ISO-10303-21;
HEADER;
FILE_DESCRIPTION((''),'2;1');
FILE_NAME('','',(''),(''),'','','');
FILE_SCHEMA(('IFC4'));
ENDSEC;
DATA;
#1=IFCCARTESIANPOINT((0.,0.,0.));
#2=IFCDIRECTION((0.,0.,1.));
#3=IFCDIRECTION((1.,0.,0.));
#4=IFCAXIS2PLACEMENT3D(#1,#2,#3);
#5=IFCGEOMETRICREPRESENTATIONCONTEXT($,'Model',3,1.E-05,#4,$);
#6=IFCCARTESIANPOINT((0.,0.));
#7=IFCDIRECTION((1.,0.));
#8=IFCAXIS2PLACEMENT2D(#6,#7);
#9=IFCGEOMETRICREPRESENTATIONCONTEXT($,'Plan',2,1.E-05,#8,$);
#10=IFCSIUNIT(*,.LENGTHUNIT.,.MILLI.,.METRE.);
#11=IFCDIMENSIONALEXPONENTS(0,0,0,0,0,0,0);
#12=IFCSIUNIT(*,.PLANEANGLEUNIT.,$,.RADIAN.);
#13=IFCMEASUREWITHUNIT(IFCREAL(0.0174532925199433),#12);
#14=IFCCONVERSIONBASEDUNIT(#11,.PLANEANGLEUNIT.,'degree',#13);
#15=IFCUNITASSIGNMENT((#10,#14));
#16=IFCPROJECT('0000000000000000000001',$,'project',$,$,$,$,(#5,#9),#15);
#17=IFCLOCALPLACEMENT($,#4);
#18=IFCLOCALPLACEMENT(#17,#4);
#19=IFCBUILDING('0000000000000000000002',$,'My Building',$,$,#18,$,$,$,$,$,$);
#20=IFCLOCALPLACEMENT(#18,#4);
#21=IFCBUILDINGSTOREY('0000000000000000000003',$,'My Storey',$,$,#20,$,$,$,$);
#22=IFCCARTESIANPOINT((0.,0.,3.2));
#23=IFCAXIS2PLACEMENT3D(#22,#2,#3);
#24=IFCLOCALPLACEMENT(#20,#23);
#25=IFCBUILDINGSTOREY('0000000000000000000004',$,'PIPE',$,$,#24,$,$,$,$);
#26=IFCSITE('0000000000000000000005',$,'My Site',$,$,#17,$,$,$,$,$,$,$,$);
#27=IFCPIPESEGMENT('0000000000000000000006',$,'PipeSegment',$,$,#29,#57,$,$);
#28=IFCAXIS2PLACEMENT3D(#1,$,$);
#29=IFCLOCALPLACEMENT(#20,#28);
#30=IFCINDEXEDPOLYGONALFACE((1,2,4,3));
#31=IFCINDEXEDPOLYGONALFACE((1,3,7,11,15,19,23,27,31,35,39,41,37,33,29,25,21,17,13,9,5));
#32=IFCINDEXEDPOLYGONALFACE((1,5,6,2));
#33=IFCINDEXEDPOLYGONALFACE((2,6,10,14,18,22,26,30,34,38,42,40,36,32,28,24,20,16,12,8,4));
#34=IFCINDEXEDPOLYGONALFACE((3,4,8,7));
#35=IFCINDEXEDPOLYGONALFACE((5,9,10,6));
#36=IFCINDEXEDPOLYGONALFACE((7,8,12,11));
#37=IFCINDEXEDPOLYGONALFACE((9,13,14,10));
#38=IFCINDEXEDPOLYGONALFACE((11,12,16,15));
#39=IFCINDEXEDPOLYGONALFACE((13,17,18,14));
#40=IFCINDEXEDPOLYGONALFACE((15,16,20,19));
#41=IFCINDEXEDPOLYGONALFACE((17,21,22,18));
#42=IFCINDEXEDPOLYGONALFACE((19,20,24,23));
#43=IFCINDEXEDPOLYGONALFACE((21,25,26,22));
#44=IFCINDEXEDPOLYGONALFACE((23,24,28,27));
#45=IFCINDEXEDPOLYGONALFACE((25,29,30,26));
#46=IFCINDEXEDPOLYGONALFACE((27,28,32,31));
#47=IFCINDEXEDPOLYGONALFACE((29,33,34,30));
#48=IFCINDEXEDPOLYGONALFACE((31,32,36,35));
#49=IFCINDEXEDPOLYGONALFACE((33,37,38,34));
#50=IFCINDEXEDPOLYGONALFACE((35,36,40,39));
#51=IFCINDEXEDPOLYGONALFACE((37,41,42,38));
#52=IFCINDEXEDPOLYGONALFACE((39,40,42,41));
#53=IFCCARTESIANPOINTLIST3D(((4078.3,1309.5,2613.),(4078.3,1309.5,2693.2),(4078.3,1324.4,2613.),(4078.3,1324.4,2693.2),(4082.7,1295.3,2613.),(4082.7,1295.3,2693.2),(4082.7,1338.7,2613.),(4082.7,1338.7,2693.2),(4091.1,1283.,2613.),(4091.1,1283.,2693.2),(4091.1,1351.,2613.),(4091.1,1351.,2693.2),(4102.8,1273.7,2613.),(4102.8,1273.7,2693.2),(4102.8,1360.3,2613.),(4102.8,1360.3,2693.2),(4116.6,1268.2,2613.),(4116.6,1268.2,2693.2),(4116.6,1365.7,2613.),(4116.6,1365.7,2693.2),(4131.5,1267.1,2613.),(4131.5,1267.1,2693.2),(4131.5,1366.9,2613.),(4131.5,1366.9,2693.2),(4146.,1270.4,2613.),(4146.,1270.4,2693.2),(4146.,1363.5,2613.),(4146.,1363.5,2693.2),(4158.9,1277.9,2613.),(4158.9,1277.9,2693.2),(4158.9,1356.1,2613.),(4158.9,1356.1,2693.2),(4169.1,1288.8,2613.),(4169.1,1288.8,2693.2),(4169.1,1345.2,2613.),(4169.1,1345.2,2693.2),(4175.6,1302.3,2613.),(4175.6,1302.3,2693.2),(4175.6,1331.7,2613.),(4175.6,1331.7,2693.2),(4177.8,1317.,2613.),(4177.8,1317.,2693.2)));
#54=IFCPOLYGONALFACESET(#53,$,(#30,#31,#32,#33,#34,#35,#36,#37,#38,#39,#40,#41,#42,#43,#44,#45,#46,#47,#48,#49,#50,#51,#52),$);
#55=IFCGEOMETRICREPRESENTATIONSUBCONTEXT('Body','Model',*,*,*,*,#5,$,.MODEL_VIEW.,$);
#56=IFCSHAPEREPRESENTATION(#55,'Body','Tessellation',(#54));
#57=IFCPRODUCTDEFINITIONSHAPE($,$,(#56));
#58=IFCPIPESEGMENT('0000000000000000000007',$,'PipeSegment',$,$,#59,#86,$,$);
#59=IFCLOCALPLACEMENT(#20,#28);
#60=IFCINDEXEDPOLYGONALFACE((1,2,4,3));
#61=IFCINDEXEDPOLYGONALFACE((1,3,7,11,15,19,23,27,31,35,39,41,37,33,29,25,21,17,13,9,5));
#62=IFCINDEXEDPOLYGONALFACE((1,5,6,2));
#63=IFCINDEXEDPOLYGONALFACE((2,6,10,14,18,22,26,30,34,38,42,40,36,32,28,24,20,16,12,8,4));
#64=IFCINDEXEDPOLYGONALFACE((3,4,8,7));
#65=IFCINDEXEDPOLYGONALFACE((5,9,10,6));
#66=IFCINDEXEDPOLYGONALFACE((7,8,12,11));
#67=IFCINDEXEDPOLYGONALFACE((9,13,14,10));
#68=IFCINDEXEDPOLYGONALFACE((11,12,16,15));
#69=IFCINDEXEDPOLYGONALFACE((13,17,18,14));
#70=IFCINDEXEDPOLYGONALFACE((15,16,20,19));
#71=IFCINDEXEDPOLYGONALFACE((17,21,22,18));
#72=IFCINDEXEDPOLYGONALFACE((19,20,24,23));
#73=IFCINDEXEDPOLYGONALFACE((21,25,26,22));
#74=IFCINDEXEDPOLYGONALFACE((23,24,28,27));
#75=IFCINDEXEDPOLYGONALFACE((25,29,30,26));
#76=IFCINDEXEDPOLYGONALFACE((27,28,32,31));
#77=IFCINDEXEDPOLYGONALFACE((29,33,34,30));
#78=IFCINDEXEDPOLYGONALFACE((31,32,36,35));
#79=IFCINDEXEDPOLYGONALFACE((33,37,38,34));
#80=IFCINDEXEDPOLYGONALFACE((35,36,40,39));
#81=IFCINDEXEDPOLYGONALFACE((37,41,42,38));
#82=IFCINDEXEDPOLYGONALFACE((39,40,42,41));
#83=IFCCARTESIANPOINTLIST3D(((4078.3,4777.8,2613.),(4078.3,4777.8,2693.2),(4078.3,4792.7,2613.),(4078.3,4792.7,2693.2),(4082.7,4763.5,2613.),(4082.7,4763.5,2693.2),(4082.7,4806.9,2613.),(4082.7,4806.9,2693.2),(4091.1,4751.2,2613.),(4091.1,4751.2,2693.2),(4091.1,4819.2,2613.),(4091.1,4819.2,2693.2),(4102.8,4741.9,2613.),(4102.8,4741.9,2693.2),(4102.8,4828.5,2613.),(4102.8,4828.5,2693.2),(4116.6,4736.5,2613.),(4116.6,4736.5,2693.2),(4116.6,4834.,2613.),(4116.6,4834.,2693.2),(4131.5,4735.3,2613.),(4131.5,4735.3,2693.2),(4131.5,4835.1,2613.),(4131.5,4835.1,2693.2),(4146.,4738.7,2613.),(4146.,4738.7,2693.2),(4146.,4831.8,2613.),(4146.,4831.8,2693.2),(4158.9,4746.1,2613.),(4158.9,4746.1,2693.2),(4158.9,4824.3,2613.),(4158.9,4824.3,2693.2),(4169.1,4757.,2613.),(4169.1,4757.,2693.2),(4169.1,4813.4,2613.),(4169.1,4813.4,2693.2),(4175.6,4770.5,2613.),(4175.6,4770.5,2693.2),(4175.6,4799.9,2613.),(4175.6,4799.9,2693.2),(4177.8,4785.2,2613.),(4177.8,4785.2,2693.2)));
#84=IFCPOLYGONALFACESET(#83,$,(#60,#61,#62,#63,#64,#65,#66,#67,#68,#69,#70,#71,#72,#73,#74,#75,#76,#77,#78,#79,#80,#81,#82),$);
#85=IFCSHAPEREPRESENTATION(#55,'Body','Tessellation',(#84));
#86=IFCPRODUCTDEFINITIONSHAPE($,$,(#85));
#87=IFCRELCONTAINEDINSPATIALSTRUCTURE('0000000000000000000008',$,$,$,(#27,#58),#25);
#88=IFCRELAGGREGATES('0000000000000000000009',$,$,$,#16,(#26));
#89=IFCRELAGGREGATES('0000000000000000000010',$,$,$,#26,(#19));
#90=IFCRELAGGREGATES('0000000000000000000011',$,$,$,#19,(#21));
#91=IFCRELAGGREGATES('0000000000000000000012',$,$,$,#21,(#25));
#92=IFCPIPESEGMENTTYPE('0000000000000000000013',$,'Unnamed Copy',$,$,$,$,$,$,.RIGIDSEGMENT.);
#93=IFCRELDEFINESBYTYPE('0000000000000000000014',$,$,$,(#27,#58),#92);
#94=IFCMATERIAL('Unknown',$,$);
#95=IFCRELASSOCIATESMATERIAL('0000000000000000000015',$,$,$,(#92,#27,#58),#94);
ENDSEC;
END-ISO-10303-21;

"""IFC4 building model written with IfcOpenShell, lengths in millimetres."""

from ifc_helpers import new_model, entity, si_unit, converted_unit, frame, origin_with_axes, origin_2d_with_axis, place, context, subcontext, project, spatial, circle, extrude, material, material_profile, profile_set, profile_usage, type_object, element, save


model = new_model("IFC4")

# Units and contexts
model_context = context("Model", 3, precision=1e-05, world=origin_with_axes())
plan_context = context("Plan", 2, precision=1e-05, world=origin_2d_with_axis())
body_context = subcontext(model_context, "Body", "Model", "MODEL_VIEW")
ifc_project = project(units=[si_unit("LENGTHUNIT", "METRE", prefix="MILLI"), converted_unit("PLANEANGLEUNIT", "degree", entity("IfcReal", 0.0174532925199433), si_unit("PLANEANGLEUNIT", "RADIAN"), dimensions=[0, 0, 0, 0, 0, 0, 0])], contexts=[model_context, plan_context])

# Site, building, storeys
site_placement = place(None, origin_with_axes())
site = spatial("IfcSite", under=ifc_project, at=site_placement, Name="My Site")
building_placement = place(site_placement, origin_with_axes())
building = spatial("IfcBuilding", under=site, at=building_placement, Name="My Building")
storey_1_placement = place(building_placement, origin_with_axes())
storey_1 = spatial("IfcBuildingStorey", under=building, at=storey_1_placement, Name="My Storey")
storey_2_placement = place(storey_1_placement, frame((0.0, 0.0, 3.2), z_axis=(0.0, 0.0, 1.0), x_axis=(1.0, 0.0, 0.0)))
storey_2 = spatial("IfcBuildingStorey", under=storey_1, at=storey_2_placement, Name="PIPE")

# Pipe segments
ifc_material = material(Name="Unknown")
ifc_material_profile_1 = material_profile(ifc_material, circle(Radius=50.0))
ifc_profile_set_1 = profile_set([ifc_material_profile_1])
pipe_segment_type = type_object("IfcPipeSegmentType", Name="Unnamed Copy", PredefinedType="RIGIDSEGMENT", material=ifc_profile_set_1)
ifc_profile_usage_1 = profile_usage(ifc_profile_set_1, cardinal=10)
pipe_segment_1_placement = place(storey_2_placement, frame((4127.8, 1317.0, 2690.0), z_axis=(0.0, 0.0, -1.0), x_axis=(1.0, 0.0, 0.0)))
element("IfcPipeSegment", 1, at=pipe_segment_1_placement, inside=storey_2, type_object=pipe_segment_type, material=ifc_profile_usage_1, Name="PipeSegment", context=body_context, shape_type="SweptSolid", body=[
    extrude(circle(Radius=50.0), origin_with_axes(), (0.0, 0.0, 1.0), 80.1),
])
ifc_profile_usage_2 = profile_usage(ifc_profile_set_1, cardinal=10)
pipe_segment_2_placement = place(storey_2_placement, frame((4127.8, 4785.2, 2690.0), z_axis=(0.0, 0.0, -1.0), x_axis=(1.0, 0.0, 0.0)))
element("IfcPipeSegment", 2, at=pipe_segment_2_placement, inside=storey_2, type_object=pipe_segment_type, material=ifc_profile_usage_2, Name="PipeSegment", context=body_context, shape_type="SweptSolid", body=[
    extrude(circle(Radius=50.0), origin_with_axes(), (0.0, 0.0, 1.0), 80.1),
])

save(model, "model.ifc")
